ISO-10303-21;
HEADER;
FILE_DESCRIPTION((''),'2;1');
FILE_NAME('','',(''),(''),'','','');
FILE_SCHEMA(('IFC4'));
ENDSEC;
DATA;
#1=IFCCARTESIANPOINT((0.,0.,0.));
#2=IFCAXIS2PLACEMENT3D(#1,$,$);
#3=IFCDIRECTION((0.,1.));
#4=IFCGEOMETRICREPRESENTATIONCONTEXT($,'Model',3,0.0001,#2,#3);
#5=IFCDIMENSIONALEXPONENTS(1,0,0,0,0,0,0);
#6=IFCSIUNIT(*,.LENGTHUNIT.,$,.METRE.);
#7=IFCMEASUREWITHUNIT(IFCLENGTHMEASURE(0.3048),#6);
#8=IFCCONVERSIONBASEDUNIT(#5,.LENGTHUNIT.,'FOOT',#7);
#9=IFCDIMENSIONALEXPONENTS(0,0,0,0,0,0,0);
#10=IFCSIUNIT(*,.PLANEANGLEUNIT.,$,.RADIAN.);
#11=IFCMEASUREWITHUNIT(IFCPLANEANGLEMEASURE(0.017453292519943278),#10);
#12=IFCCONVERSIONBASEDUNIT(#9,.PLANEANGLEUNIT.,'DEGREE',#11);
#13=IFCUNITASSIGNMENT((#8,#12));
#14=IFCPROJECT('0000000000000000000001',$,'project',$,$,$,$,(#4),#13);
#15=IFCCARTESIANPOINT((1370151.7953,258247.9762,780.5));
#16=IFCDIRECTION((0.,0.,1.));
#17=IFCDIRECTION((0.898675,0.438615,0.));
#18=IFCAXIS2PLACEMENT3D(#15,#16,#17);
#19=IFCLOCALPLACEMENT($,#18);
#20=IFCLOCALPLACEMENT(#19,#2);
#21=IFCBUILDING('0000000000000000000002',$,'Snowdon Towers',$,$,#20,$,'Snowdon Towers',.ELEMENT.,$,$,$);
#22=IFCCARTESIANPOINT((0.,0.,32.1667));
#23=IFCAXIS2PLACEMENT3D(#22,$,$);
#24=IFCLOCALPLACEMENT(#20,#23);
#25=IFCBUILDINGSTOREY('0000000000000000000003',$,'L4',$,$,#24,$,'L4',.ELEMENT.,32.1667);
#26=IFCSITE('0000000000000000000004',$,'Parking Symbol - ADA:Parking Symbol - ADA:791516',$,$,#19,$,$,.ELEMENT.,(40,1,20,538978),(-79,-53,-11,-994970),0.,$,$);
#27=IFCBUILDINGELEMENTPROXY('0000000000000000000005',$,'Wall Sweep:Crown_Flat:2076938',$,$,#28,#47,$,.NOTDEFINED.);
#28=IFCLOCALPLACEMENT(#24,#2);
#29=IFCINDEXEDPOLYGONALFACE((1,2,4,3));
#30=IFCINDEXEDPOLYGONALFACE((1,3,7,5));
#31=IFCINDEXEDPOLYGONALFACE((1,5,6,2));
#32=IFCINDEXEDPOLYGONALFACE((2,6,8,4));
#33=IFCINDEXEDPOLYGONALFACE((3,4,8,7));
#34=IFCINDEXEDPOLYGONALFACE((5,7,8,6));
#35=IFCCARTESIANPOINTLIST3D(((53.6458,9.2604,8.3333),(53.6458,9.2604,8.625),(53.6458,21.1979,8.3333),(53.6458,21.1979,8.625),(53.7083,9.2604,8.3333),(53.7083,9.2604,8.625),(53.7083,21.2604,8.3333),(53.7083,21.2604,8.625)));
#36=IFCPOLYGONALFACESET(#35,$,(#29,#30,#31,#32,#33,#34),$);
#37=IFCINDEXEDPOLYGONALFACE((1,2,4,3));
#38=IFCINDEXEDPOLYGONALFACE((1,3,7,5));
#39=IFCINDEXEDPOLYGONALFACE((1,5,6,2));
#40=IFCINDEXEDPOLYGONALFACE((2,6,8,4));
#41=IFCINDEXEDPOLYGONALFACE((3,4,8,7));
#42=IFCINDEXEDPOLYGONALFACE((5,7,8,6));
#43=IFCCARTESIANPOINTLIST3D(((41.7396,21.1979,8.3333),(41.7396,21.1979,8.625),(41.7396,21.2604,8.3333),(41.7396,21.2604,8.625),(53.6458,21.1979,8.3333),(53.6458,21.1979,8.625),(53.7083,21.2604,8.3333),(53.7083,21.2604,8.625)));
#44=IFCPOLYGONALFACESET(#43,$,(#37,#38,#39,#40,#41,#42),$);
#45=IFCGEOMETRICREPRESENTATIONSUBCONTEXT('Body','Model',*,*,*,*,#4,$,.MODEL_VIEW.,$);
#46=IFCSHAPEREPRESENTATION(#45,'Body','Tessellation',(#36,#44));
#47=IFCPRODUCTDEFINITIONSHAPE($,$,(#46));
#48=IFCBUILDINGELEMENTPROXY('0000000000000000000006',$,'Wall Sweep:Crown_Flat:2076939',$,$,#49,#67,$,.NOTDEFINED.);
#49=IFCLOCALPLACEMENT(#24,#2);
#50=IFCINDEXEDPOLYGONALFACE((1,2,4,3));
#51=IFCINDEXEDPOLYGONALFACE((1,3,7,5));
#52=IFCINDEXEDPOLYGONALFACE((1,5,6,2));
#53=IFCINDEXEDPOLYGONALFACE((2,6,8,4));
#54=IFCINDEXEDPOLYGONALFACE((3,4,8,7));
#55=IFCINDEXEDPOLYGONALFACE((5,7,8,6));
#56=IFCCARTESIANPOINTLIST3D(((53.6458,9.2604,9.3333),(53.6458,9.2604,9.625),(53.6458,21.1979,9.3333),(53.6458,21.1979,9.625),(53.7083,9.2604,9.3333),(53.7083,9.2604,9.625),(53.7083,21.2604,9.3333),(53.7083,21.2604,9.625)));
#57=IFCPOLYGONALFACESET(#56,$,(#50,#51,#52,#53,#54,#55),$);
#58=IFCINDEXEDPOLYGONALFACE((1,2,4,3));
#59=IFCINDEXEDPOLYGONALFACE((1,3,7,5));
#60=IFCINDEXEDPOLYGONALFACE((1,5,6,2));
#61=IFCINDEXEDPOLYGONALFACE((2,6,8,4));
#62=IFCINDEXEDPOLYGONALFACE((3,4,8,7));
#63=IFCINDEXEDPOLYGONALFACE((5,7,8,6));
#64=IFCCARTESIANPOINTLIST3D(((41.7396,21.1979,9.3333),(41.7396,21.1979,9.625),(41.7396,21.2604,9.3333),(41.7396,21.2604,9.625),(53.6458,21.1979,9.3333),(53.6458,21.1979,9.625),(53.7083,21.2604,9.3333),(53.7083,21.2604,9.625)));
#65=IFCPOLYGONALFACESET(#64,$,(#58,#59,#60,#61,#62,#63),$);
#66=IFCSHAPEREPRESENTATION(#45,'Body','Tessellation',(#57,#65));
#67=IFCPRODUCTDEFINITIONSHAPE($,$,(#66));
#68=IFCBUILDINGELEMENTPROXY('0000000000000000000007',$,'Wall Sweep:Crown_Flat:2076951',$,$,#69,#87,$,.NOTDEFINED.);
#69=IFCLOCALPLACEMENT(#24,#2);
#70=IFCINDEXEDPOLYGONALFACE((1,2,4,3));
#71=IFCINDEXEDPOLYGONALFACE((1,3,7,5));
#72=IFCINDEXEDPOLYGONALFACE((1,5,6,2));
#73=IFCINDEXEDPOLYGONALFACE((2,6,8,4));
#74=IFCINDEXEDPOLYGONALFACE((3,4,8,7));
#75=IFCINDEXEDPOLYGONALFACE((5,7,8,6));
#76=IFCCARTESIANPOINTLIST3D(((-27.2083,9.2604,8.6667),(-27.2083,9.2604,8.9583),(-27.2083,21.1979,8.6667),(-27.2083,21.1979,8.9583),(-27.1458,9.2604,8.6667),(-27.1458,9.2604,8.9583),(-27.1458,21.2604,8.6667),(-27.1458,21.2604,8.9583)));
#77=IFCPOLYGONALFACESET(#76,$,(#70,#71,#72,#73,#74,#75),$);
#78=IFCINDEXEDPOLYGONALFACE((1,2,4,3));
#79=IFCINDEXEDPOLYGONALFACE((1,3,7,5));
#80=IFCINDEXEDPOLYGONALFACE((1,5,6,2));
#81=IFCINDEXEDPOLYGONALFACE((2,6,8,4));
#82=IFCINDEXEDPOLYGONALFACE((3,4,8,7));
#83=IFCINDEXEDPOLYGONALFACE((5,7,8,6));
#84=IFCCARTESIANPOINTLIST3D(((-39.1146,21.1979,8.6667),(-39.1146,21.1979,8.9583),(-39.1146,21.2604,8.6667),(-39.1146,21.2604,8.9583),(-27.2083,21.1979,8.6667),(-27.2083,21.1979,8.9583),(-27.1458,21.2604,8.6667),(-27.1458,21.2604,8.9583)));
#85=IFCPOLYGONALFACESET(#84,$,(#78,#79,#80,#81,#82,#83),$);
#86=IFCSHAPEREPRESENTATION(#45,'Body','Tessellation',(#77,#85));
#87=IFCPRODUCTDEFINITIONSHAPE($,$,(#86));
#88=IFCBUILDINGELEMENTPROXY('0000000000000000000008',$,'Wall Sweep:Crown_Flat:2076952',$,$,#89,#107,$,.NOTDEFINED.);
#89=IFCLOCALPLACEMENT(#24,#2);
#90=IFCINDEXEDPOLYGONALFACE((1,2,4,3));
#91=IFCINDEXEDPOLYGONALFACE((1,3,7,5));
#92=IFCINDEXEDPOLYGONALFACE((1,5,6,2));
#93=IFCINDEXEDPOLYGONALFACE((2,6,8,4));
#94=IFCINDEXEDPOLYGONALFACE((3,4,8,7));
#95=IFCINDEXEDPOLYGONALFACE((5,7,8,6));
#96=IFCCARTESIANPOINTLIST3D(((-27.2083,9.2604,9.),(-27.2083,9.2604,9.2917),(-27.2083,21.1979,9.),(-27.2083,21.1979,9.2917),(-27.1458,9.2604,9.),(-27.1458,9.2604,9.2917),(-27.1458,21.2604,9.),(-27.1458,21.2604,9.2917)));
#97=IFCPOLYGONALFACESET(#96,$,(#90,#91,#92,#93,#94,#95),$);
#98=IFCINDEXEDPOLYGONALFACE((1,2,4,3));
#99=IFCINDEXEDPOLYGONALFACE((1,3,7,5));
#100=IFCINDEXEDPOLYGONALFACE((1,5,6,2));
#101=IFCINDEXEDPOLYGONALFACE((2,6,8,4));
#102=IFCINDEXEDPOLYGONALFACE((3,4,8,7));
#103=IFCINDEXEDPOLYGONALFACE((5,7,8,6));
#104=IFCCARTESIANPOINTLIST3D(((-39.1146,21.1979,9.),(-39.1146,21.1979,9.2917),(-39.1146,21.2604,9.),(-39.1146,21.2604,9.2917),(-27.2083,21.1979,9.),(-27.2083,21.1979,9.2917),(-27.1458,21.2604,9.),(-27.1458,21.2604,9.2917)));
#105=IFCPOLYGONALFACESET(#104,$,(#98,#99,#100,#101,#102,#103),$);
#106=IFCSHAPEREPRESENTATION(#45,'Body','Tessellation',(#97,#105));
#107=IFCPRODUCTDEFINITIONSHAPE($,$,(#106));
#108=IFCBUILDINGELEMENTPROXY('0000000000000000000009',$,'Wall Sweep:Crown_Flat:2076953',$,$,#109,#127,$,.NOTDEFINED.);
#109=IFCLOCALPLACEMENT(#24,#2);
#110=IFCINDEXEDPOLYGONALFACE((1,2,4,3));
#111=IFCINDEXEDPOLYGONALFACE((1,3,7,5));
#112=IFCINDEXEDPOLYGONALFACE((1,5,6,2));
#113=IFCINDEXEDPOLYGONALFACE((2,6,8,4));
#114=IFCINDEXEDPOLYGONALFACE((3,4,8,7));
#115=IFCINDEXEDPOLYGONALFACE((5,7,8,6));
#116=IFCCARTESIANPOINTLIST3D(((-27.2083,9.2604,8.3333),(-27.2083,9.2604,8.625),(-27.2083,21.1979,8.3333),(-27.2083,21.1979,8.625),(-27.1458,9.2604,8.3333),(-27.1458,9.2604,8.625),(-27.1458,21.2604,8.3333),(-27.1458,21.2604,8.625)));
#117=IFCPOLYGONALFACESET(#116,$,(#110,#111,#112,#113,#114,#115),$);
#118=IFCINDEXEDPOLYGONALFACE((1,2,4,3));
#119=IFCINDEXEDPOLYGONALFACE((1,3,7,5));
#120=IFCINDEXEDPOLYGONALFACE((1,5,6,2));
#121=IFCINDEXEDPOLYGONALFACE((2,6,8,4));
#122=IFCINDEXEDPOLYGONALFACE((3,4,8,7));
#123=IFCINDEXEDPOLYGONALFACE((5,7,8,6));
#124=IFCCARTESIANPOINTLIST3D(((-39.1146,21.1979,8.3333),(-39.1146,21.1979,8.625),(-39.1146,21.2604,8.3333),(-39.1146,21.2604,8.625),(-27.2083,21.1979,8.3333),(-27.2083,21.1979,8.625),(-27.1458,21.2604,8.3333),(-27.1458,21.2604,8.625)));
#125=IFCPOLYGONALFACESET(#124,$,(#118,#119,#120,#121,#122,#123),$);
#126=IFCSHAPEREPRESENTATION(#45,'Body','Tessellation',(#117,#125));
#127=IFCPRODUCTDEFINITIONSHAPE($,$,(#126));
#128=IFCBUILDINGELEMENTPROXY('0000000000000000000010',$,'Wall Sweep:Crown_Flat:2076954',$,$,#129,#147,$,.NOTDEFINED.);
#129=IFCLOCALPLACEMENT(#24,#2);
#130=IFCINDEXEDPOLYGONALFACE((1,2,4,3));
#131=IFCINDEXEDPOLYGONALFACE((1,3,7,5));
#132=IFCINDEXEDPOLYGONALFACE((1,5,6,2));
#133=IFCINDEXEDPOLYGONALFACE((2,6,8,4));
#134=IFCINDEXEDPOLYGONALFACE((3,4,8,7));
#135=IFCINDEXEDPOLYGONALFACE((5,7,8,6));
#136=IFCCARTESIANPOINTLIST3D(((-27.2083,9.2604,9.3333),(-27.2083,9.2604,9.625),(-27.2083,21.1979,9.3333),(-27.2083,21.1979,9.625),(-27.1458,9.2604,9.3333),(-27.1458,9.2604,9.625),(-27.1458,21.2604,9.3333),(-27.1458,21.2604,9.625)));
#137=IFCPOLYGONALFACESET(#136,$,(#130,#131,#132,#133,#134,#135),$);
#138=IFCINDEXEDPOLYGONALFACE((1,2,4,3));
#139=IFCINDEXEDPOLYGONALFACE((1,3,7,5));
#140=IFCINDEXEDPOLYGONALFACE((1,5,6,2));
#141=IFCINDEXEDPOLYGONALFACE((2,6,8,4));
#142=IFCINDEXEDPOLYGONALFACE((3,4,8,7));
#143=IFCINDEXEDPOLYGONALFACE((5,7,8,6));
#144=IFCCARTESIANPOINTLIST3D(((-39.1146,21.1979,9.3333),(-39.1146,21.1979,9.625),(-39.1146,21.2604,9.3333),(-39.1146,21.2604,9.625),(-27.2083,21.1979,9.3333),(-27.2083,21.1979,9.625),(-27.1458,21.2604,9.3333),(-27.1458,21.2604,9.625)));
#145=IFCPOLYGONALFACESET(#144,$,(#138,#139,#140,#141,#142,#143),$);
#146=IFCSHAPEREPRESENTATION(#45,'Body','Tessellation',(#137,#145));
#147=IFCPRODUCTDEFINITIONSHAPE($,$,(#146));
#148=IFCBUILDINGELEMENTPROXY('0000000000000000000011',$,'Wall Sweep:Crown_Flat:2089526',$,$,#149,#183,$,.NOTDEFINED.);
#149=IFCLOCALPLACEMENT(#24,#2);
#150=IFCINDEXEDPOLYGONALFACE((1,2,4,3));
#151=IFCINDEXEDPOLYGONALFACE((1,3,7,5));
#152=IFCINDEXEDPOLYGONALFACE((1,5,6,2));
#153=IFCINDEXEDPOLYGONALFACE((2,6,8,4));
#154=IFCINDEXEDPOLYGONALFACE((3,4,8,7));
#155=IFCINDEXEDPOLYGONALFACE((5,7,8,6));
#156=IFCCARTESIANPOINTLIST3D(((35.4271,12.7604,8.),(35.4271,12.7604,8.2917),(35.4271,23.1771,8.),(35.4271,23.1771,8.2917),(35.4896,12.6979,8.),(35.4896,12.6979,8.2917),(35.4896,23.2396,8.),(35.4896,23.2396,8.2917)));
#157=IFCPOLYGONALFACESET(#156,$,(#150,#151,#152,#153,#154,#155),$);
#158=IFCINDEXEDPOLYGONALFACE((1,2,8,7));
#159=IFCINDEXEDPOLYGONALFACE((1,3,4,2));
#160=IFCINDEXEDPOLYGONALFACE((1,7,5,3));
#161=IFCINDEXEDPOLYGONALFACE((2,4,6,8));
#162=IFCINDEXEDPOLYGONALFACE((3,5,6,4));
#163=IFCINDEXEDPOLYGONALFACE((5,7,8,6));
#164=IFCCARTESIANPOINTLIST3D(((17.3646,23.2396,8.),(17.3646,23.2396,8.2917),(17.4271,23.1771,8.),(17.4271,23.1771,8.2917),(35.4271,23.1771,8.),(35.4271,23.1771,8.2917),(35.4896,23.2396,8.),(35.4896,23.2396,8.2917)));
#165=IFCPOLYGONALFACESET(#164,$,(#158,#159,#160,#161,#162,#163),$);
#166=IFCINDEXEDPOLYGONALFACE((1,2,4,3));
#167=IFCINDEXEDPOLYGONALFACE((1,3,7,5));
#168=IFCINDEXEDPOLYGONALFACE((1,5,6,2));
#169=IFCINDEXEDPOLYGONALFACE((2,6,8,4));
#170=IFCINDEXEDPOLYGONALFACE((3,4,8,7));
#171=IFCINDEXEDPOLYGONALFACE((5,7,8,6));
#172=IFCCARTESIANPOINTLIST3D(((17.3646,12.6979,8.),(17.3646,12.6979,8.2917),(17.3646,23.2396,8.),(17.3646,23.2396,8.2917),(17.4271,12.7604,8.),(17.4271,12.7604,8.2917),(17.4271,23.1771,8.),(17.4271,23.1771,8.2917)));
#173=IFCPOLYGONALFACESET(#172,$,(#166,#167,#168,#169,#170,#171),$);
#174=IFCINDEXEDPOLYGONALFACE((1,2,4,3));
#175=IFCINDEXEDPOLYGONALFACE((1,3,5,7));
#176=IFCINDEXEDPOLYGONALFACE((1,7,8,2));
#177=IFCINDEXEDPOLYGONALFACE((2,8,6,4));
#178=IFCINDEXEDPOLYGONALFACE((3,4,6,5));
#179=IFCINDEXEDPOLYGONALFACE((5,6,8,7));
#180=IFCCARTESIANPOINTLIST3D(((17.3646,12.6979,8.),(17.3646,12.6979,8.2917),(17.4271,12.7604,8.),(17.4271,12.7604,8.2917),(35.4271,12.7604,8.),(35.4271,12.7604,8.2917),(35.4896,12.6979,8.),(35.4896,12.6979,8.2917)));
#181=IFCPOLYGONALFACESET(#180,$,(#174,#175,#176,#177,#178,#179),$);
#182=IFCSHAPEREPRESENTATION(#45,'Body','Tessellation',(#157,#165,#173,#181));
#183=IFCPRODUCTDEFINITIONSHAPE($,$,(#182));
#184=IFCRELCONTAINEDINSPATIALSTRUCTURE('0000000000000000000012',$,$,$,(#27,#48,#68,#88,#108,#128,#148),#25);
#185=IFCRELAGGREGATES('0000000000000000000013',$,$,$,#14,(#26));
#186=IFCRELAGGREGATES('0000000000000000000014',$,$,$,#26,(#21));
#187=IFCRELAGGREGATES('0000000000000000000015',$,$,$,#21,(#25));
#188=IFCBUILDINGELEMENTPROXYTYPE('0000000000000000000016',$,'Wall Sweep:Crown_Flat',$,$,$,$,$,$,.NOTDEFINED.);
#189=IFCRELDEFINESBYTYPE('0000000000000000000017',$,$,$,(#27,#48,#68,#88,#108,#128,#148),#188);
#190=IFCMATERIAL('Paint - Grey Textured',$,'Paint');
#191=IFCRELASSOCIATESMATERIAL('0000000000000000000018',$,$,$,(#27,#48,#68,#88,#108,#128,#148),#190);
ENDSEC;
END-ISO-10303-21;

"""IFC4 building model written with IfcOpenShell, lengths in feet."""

from ifc_helpers import new_model, entity, si_unit, converted_unit, direction, frame, origin, place, context, subcontext, project, spatial, indexed_curve, outline, extrude, material, type_object, element, save


model = new_model("IFC4")

# Units and contexts
model_context = context("Model", 3, precision=0.0001, world=origin(), true_north=direction((0.0, 1.0)))
body_context = subcontext(model_context, "Body", "Model", "MODEL_VIEW")
ifc_project = project(units=[converted_unit("LENGTHUNIT", "FOOT", entity("IfcLengthMeasure", 0.3048), si_unit("LENGTHUNIT", "METRE"), dimensions=[1, 0, 0, 0, 0, 0, 0]), converted_unit("PLANEANGLEUNIT", "DEGREE", entity("IfcPlaneAngleMeasure", 0.017453292519943278), si_unit("PLANEANGLEUNIT", "RADIAN"), dimensions=[0, 0, 0, 0, 0, 0, 0])], contexts=[model_context])

# Site, building, storey
site_placement = place(None, frame((1370151.7953, 258247.9762, 780.5), z_axis=(0.0, 0.0, 1.0), x_axis=(0.898675, 0.438615, 0.0)))
site = spatial("IfcSite", under=ifc_project, at=site_placement, Name="Parking Symbol - ADA:Parking Symbol - ADA:791516", CompositionType="ELEMENT", RefLatitude=(40, 1, 20, 538978), RefLongitude=(-79, -53, -11, -994970), RefElevation=0.0)
building_placement = place(site_placement, origin())
building = spatial("IfcBuilding", under=site, at=building_placement, Name="Snowdon Towers", LongName="Snowdon Towers", CompositionType="ELEMENT")
storey_placement = place(building_placement, frame((0.0, 0.0, 32.1667)))
storey = spatial("IfcBuildingStorey", under=building, at=storey_placement, Name="L4", LongName="L4", CompositionType="ELEMENT", Elevation=32.1667)

# Building element proxies
ifc_material_1 = material(Name="Paint - Grey Textured", Category="Paint")
building_element_proxy_type_1 = type_object("IfcBuildingElementProxyType", Name="Wall Sweep:Crown_Flat", PredefinedType="NOTDEFINED")
proxy_1_placement = place(storey_placement, origin())
element("IfcBuildingElementProxy", 1, at=proxy_1_placement, inside=storey, type_object=building_element_proxy_type_1, material=ifc_material_1, Name="Wall Sweep:Crown_Flat:2076938", PredefinedType="NOTDEFINED", context=body_context, shape_type="SweptSolid", body=[
    extrude(outline(indexed_curve([(-5.9531, -0.0312), (5.9844, -0.0312), (5.9844, 0.0312), (-6.0156, 0.0312), (-5.9531, -0.0312)], self_intersect=False)), frame((53.6771, 15.2448, 8.3333), z_axis=(0.0, 0.0, 1.0), x_axis=(0.0, -1.0, 0.0)), (0.0, 0.0, 1.0), 0.2917),
    extrude(outline(indexed_curve([(-5.9688, -0.0312), (5.9375, -0.0312), (6.0, 0.0313), (-5.9688, 0.0313), (-5.9688, -0.0312)], self_intersect=False)), frame((47.7083, 21.2292, 8.3333)), (0.0, 0.0, 1.0), 0.2917),
])
proxy_2_placement = place(storey_placement, origin())
element("IfcBuildingElementProxy", 2, at=proxy_2_placement, inside=storey, type_object=building_element_proxy_type_1, material=ifc_material_1, Name="Wall Sweep:Crown_Flat:2076939", PredefinedType="NOTDEFINED", context=body_context, shape_type="SweptSolid", body=[
    extrude(outline(indexed_curve([(-5.9531, -0.0312), (5.9844, -0.0312), (5.9844, 0.0312), (-6.0156, 0.0312), (-5.9531, -0.0312)], self_intersect=False)), frame((53.6771, 15.2448, 9.3333), z_axis=(0.0, 0.0, 1.0), x_axis=(0.0, -1.0, 0.0)), (0.0, 0.0, 1.0), 0.2917),
    extrude(outline(indexed_curve([(-5.9688, -0.0312), (5.9375, -0.0312), (6.0, 0.0313), (-5.9688, 0.0313), (-5.9688, -0.0312)], self_intersect=False)), frame((47.7083, 21.2292, 9.3333)), (0.0, 0.0, 1.0), 0.2917),
])
proxy_3_placement = place(storey_placement, origin())
element("IfcBuildingElementProxy", 3, at=proxy_3_placement, inside=storey, type_object=building_element_proxy_type_1, material=ifc_material_1, Name="Wall Sweep:Crown_Flat:2076951", PredefinedType="NOTDEFINED", context=body_context, shape_type="SweptSolid", body=[
    extrude(outline(indexed_curve([(-5.9531, -0.0312), (5.9844, -0.0312), (5.9844, 0.0312), (-6.0156, 0.0312), (-5.9531, -0.0312)], self_intersect=False)), frame((-27.1771, 15.2448, 8.6667), z_axis=(0.0, 0.0, 1.0), x_axis=(0.0, -1.0, 0.0)), (0.0, 0.0, 1.0), 0.2917),
    extrude(outline(indexed_curve([(-5.9688, -0.0312), (5.9375, -0.0312), (6.0, 0.0313), (-5.9688, 0.0313), (-5.9688, -0.0312)], self_intersect=False)), frame((-33.1458, 21.2292, 8.6667)), (0.0, 0.0, 1.0), 0.2917),
])
proxy_4_placement = place(storey_placement, origin())
element("IfcBuildingElementProxy", 4, at=proxy_4_placement, inside=storey, type_object=building_element_proxy_type_1, material=ifc_material_1, Name="Wall Sweep:Crown_Flat:2076952", PredefinedType="NOTDEFINED", context=body_context, shape_type="SweptSolid", body=[
    extrude(outline(indexed_curve([(-5.9531, -0.0312), (5.9844, -0.0312), (5.9844, 0.0312), (-6.0156, 0.0312), (-5.9531, -0.0312)], self_intersect=False)), frame((-27.1771, 15.2448, 9.0), z_axis=(0.0, 0.0, 1.0), x_axis=(0.0, -1.0, 0.0)), (0.0, 0.0, 1.0), 0.2917),
    extrude(outline(indexed_curve([(-5.9688, -0.0312), (5.9375, -0.0312), (6.0, 0.0313), (-5.9688, 0.0313), (-5.9688, -0.0312)], self_intersect=False)), frame((-33.1458, 21.2292, 9.0)), (0.0, 0.0, 1.0), 0.2917),
])
proxy_5_placement = place(storey_placement, origin())
element("IfcBuildingElementProxy", 5, at=proxy_5_placement, inside=storey, type_object=building_element_proxy_type_1, material=ifc_material_1, Name="Wall Sweep:Crown_Flat:2076953", PredefinedType="NOTDEFINED", context=body_context, shape_type="SweptSolid", body=[
    extrude(outline(indexed_curve([(-5.9531, -0.0312), (5.9844, -0.0312), (5.9844, 0.0312), (-6.0156, 0.0312), (-5.9531, -0.0312)], self_intersect=False)), frame((-27.1771, 15.2448, 8.3333), z_axis=(0.0, 0.0, 1.0), x_axis=(0.0, -1.0, 0.0)), (0.0, 0.0, 1.0), 0.2917),
    extrude(outline(indexed_curve([(-5.9688, -0.0312), (5.9375, -0.0312), (6.0, 0.0313), (-5.9688, 0.0313), (-5.9688, -0.0312)], self_intersect=False)), frame((-33.1458, 21.2292, 8.3333)), (0.0, 0.0, 1.0), 0.2917),
])
proxy_6_placement = place(storey_placement, origin())
element("IfcBuildingElementProxy", 6, at=proxy_6_placement, inside=storey, type_object=building_element_proxy_type_1, material=ifc_material_1, Name="Wall Sweep:Crown_Flat:2076954", PredefinedType="NOTDEFINED", context=body_context, shape_type="SweptSolid", body=[
    extrude(outline(indexed_curve([(-5.9531, -0.0312), (5.9844, -0.0312), (5.9844, 0.0312), (-6.0156, 0.0312), (-5.9531, -0.0312)], self_intersect=False)), frame((-27.1771, 15.2448, 9.3333), z_axis=(0.0, 0.0, 1.0), x_axis=(0.0, -1.0, 0.0)), (0.0, 0.0, 1.0), 0.2917),
    extrude(outline(indexed_curve([(-5.9688, -0.0312), (5.9375, -0.0312), (6.0, 0.0313), (-5.9688, 0.0313), (-5.9688, -0.0312)], self_intersect=False)), frame((-33.1458, 21.2292, 9.3333)), (0.0, 0.0, 1.0), 0.2917),
])
proxy_7_placement = place(storey_placement, origin())
element("IfcBuildingElementProxy", 7, at=proxy_7_placement, inside=storey, type_object=building_element_proxy_type_1, material=ifc_material_1, Name="Wall Sweep:Crown_Flat:2089526", PredefinedType="NOTDEFINED", context=body_context, shape_type="SweptSolid", body=[
    extrude(outline(indexed_curve([(-5.2083, -0.0312), (5.2083, -0.0312), (5.2708, 0.0312), (-5.2708, 0.0312), (-5.2083, -0.0312)], self_intersect=False)), frame((35.4583, 17.9687, 8.0), z_axis=(0.0, 0.0, 1.0), x_axis=(0.0, -1.0, 0.0)), (0.0, 0.0, 1.0), 0.2917),
    extrude(outline(indexed_curve([(-9.0, -0.0313), (9.0, -0.0313), (9.0625, 0.0312), (-9.0625, 0.0312), (-9.0, -0.0313)], self_intersect=False)), frame((26.4271, 23.2083, 8.0)), (0.0, 0.0, 1.0), 0.2917),
    extrude(outline(indexed_curve([(-5.2083, -0.0313), (5.2083, -0.0312), (5.2708, 0.0313), (-5.2708, 0.0312), (-5.2083, -0.0313)], self_intersect=False)), frame((17.3958, 17.9687, 8.0), z_axis=(0.0, 0.0, 1.0), x_axis=(0.0, 1.0, 0.0)), (0.0, 0.0, 1.0), 0.2917),
    extrude(outline(indexed_curve([(-9.0, -0.0312), (9.0, -0.0312), (9.0625, 0.0312), (-9.0625, 0.0313), (-9.0, -0.0312)], self_intersect=False)), frame((26.4271, 12.7292, 8.0), z_axis=(0.0, 0.0, 1.0), x_axis=(-1.0, 0.0, 0.0)), (0.0, 0.0, 1.0), 0.2917),
])

save(model, "model.ifc")
